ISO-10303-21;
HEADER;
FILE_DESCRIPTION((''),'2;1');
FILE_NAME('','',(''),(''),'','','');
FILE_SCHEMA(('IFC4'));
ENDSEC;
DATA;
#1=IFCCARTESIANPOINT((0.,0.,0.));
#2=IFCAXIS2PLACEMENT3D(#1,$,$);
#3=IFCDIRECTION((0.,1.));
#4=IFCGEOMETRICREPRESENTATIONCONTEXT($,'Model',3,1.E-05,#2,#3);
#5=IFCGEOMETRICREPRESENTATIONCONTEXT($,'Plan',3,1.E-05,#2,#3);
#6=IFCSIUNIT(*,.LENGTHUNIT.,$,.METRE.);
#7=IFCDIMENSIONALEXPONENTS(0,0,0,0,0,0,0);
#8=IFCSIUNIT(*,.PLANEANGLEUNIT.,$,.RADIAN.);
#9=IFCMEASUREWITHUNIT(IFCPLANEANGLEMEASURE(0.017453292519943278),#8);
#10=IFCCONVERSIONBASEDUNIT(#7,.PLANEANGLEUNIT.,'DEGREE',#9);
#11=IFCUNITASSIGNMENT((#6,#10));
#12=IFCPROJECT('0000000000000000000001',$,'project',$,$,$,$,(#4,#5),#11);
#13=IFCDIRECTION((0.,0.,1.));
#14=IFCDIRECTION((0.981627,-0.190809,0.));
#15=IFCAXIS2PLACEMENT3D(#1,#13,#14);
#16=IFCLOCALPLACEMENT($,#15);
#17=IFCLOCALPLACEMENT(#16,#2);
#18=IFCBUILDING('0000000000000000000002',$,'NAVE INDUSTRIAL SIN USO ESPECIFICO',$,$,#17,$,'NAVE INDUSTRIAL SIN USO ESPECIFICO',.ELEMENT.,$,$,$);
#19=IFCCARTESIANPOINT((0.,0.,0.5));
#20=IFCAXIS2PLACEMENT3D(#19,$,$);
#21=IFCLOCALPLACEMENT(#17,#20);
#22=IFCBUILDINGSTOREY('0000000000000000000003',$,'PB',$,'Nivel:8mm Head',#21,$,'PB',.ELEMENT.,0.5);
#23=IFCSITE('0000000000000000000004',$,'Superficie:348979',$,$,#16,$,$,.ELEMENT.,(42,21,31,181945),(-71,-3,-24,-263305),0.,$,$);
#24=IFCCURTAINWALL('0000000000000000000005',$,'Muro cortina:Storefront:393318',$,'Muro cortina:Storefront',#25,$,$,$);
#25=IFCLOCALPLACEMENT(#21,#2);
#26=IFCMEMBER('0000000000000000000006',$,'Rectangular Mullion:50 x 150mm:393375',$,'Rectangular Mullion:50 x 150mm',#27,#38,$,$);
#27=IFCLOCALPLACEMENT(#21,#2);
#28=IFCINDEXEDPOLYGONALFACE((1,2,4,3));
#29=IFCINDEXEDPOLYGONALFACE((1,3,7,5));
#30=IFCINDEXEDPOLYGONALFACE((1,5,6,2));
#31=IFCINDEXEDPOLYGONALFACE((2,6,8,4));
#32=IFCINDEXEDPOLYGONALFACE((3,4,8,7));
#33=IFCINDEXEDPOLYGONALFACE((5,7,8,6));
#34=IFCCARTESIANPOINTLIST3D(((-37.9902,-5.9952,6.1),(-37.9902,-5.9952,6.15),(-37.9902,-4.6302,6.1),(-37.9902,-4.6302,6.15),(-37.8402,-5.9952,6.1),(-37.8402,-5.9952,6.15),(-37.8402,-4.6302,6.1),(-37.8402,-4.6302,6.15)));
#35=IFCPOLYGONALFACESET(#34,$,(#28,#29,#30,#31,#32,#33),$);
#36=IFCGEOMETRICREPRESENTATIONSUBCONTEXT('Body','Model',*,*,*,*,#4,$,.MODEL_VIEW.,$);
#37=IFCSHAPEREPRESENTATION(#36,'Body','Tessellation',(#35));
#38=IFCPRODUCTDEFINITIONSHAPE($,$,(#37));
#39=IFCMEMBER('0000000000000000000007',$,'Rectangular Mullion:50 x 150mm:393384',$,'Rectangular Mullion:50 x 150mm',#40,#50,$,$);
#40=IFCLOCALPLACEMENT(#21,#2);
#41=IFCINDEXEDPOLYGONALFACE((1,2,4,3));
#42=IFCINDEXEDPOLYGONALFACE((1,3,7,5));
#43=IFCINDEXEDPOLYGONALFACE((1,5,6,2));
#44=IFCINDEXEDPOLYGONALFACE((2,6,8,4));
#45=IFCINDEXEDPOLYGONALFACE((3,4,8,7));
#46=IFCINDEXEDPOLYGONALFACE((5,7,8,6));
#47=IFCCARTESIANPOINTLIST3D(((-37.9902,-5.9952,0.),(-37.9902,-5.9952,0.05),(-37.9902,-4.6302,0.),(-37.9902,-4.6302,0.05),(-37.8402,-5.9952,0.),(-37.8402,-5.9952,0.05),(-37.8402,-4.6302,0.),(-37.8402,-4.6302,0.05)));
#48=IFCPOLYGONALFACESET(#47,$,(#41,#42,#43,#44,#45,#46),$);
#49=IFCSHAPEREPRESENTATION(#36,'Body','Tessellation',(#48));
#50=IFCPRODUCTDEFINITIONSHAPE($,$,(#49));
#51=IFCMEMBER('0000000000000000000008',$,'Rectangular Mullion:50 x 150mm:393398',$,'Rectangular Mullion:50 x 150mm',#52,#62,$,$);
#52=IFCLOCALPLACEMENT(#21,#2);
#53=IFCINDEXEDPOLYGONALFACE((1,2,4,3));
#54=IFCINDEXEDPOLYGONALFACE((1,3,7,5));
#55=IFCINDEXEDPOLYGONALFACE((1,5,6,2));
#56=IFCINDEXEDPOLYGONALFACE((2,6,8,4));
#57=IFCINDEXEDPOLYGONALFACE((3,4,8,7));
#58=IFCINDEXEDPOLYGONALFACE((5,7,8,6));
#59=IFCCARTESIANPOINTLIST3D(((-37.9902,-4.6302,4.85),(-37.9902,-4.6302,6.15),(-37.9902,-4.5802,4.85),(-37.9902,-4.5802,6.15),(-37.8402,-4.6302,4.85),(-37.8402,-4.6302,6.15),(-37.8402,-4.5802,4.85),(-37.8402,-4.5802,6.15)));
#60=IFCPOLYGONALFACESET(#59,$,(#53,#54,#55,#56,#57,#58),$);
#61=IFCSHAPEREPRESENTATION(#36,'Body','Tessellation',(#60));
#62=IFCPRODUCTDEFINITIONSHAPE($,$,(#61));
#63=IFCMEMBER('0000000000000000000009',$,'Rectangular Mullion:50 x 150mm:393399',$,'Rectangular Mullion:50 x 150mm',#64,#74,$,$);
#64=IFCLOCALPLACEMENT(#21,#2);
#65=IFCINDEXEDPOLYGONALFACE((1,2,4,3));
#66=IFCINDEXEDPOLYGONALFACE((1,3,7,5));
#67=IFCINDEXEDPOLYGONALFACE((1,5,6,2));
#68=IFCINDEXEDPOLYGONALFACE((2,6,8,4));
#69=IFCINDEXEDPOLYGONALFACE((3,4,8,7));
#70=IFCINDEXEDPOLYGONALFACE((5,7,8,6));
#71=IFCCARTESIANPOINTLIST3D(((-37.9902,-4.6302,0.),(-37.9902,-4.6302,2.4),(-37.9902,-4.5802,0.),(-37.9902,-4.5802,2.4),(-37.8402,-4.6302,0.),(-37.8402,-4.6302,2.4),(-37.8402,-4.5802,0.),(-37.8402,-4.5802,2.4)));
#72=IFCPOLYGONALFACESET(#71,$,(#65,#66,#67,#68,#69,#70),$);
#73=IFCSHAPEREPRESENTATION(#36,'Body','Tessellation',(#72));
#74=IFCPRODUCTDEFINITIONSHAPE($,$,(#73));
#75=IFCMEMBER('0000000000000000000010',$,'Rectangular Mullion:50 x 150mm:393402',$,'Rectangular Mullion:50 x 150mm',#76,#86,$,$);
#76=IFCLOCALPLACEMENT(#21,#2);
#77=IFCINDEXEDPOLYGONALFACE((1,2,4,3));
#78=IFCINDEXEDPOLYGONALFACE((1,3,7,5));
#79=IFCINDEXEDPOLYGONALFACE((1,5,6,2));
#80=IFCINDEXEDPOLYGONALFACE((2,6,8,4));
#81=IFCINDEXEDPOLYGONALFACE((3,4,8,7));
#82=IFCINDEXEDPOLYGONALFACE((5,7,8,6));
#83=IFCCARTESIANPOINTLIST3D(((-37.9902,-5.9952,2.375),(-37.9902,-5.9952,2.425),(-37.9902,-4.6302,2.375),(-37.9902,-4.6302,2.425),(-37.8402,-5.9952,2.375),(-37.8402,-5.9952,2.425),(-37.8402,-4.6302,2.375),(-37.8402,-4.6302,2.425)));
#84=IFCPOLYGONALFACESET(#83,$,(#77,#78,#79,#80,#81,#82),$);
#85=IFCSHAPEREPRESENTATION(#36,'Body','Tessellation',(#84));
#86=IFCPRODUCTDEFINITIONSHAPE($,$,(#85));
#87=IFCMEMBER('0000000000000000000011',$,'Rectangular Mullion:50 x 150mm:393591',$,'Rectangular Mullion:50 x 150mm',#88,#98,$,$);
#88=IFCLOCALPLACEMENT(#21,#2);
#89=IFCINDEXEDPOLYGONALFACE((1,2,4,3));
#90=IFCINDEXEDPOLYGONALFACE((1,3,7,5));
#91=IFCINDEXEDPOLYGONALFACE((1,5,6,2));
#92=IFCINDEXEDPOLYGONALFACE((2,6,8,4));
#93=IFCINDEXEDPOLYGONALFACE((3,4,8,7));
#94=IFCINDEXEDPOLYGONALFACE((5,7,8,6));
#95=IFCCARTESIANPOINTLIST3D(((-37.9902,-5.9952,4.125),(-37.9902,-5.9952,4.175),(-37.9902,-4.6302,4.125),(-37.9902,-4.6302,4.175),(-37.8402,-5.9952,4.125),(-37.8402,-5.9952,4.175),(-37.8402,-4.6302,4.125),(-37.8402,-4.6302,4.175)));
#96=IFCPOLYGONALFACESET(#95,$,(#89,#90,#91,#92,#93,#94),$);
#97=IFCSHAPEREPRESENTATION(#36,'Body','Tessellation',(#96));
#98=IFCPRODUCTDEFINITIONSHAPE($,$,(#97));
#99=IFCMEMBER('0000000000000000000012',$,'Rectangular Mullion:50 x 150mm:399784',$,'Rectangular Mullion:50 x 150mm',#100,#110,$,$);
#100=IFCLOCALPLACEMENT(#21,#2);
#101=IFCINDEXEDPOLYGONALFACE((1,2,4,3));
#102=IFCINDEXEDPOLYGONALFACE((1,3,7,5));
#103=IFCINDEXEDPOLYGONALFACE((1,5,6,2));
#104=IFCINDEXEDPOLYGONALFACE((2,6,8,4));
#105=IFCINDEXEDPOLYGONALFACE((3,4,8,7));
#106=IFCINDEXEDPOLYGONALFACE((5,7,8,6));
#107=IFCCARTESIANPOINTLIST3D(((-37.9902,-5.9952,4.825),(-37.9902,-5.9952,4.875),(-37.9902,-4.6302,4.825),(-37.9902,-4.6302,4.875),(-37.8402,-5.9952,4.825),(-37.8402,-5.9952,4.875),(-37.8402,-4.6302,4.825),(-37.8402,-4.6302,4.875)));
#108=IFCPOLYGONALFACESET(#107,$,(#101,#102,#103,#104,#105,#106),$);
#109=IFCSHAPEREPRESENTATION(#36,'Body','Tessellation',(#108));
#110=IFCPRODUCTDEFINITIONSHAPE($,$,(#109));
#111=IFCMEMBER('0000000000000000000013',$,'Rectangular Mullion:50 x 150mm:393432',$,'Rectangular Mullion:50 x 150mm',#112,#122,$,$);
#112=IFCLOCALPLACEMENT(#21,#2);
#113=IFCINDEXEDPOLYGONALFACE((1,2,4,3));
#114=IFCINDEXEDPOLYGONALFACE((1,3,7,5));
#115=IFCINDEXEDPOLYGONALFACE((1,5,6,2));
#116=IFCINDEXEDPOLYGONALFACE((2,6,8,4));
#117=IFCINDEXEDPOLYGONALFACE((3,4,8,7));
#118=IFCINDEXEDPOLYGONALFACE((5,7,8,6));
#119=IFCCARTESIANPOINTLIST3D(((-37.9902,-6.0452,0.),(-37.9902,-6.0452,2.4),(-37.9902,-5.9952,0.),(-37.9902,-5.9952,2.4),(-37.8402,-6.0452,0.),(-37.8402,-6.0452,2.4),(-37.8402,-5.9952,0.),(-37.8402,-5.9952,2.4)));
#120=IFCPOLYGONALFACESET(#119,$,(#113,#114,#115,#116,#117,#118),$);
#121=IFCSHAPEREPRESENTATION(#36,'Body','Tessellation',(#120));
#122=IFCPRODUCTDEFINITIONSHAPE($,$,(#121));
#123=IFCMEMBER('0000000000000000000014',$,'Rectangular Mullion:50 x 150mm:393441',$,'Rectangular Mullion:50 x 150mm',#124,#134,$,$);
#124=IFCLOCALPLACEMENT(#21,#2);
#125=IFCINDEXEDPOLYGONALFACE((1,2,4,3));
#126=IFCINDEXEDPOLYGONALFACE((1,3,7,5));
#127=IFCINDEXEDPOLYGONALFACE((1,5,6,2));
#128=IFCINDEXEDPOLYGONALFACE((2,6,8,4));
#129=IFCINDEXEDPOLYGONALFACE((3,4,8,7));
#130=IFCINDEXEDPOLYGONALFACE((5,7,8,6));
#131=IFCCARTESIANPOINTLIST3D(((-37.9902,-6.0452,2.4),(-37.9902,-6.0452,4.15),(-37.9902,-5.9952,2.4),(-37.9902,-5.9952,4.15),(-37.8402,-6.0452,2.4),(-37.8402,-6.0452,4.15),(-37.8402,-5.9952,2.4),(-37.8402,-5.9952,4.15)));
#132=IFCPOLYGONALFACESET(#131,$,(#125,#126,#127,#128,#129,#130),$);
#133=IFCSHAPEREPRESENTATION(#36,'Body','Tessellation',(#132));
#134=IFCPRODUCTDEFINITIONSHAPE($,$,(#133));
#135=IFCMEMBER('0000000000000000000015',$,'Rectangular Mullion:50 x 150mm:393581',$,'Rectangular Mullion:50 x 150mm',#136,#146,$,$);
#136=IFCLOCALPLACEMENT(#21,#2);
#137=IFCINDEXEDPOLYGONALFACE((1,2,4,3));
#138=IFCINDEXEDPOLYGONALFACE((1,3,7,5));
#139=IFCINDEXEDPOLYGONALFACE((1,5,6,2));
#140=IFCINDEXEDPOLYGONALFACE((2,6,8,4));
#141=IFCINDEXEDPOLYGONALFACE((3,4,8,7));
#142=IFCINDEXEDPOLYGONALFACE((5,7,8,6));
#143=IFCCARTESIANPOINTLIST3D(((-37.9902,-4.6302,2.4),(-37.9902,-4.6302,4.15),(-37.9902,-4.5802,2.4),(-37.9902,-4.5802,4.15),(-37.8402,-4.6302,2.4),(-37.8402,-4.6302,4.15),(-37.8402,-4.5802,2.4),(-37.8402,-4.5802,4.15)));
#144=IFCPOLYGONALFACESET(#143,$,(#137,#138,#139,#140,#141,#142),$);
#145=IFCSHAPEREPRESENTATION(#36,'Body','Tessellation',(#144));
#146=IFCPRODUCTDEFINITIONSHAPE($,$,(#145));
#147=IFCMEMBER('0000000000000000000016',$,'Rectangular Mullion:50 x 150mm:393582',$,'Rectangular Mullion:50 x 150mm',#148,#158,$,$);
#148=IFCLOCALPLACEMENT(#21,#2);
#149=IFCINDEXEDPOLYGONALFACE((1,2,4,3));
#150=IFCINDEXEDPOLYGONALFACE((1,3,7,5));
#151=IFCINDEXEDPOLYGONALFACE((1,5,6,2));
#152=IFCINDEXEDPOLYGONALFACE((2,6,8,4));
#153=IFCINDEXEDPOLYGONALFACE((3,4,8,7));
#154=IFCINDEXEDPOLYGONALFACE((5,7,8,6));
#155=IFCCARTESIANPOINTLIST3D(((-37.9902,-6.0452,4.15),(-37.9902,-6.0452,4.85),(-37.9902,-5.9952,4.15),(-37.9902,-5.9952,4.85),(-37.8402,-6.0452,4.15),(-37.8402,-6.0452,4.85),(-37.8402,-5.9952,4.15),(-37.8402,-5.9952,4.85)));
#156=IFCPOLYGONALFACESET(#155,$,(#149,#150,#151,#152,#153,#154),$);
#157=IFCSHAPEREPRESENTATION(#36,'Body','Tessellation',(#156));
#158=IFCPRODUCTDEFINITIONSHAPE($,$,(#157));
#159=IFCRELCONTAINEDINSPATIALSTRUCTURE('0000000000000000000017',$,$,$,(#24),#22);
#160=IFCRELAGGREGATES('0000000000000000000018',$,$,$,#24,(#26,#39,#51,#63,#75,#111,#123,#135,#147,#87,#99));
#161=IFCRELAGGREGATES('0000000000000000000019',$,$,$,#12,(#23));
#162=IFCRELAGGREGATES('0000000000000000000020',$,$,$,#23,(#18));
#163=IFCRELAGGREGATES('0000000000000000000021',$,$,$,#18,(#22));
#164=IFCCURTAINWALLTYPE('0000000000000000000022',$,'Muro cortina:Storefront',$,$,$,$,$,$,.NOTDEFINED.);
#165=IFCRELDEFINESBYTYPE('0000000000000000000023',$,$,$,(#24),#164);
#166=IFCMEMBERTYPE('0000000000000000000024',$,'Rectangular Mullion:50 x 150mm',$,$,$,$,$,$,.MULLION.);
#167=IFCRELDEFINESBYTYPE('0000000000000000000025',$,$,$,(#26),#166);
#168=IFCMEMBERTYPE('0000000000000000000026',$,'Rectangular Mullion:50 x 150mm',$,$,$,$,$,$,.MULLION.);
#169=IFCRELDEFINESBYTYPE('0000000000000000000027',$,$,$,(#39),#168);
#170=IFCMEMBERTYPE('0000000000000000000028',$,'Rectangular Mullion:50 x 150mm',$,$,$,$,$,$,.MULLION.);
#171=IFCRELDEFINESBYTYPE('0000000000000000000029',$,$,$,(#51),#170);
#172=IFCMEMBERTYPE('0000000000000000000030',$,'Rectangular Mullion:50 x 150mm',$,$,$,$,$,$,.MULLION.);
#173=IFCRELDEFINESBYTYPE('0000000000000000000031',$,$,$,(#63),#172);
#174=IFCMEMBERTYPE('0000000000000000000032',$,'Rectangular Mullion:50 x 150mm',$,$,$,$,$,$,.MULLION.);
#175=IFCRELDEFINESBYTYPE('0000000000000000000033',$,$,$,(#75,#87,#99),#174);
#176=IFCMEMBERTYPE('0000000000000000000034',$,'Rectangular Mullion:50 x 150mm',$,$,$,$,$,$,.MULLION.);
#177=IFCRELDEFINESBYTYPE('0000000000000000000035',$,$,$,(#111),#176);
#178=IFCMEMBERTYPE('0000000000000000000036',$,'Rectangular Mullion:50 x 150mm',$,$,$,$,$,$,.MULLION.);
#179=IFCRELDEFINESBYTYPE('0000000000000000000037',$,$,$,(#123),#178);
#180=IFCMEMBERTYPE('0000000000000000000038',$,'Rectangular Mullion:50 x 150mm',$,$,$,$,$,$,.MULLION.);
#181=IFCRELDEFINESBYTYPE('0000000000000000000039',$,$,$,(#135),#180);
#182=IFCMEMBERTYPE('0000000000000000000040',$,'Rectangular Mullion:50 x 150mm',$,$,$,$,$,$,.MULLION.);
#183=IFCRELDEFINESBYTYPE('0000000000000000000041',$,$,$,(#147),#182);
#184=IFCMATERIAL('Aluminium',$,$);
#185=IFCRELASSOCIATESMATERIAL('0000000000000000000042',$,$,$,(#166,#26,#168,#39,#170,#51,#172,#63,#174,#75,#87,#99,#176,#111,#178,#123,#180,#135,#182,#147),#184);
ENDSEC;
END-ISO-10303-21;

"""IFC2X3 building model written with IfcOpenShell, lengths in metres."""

from ifc_helpers import new_model, entity, si_unit, converted_unit, direction, frame, origin, origin_2d_with_axis, place, context, subcontext, project, spatial, rectangle, extrude, source, transform, mapped, material, type_object, type_shapes, element, aggregate, save


model = new_model("IFC2X3")

# Units and contexts
model_context = context("Model", 3, precision=1e-05, world=origin(), true_north=direction((0.0, 1.0)))
plan_context = context("Plan", 3, precision=1e-05, world=origin(), true_north=direction((0.0, 1.0)))
body_context = subcontext(model_context, "Body", "Model", "MODEL_VIEW")
ifc_project = project(units=[si_unit("LENGTHUNIT", "METRE"), converted_unit("PLANEANGLEUNIT", "DEGREE", entity("IfcPlaneAngleMeasure", 0.017453292519943278), si_unit("PLANEANGLEUNIT", "RADIAN"), dimensions=[0, 0, 0, 0, 0, 0, 0])], contexts=[model_context, plan_context])

# Site, building, storey
site_placement = place(None, frame((0.0, 0.0, 0.0), z_axis=(0.0, 0.0, 1.0), x_axis=(0.981627, -0.190809, 0.0)))
site = spatial("IfcSite", under=ifc_project, at=site_placement, Name="Superficie:348979", CompositionType="ELEMENT", RefLatitude=(42, 21, 31, 181945), RefLongitude=(-71, -3, -24, -263305), RefElevation=0.0)
building_placement = place(site_placement, origin())
building = spatial("IfcBuilding", under=site, at=building_placement, Name="NAVE INDUSTRIAL SIN USO ESPECIFICO", LongName="NAVE INDUSTRIAL SIN USO ESPECIFICO", CompositionType="ELEMENT")
storey_placement = place(building_placement, frame((0.0, 0.0, 0.5)))
storey = spatial("IfcBuildingStorey", under=building, at=storey_placement, Name="PB", ObjectType="Nivel:8mm Head", LongName="PB", CompositionType="ELEMENT", Elevation=0.5)

# Curtain wall, members
curtain_wall_type = type_object("IfcCurtainWallType", Name="Muro cortina:Storefront", PredefinedType="NOTDEFINED")
curtain_wall_placement = place(storey_placement, frame((0.0, 0.0, -0.5)))
curtain_wall = element("IfcCurtainWall", 1, at=curtain_wall_placement, inside=storey, type_object=curtain_wall_type, Name="Muro cortina:Storefront:393318", ObjectType="Muro cortina:Storefront")
ifc_material_1 = material(Name="Aluminium")
member_type_1 = type_object("IfcMemberType", Name="Rectangular Mullion:50 x 150mm", PredefinedType="MULLION", material=ifc_material_1)
shared_shape_1 = source(origin(), body_context, "Body", "SweptSolid", [
    extrude(rectangle(XDim=0.05, YDim=0.15, at=origin_2d_with_axis()), frame((-0.025, 0.0, -1.365), z_axis=(0.0, 0.0, 1.0), x_axis=(-1.0, 0.0, 0.0)), (0.0, 0.0, 1.0), 1.365),
])
type_shapes(member_type_1, [shared_shape_1])
member_1_placement = place(curtain_wall_placement, frame((-37.9152, -5.9952, 6.65), z_axis=(0.0, -1.0, 0.0), x_axis=(0.0, 0.0, 1.0)))
member_1 = element("IfcMember", 2, at=member_1_placement, type_object=member_type_1, material=ifc_material_1, Name="Rectangular Mullion:50 x 150mm:393375", ObjectType="Rectangular Mullion:50 x 150mm", context=body_context, shape_type="MappedRepresentation", body=[
    mapped(shared_shape_1, transform((0.0, 0.0, 0.0), scale=1.0)),
])
member_type_2 = type_object("IfcMemberType", Name="Rectangular Mullion:50 x 150mm", PredefinedType="MULLION", material=ifc_material_1)
shared_shape_2 = source(origin(), body_context, "Body", "SweptSolid", [
    extrude(rectangle(XDim=0.05, YDim=0.15, at=origin_2d_with_axis()), frame((-0.025, 0.0, -1.365), z_axis=(0.0, 0.0, 1.0), x_axis=(-1.0, 0.0, 0.0)), (0.0, 0.0, 1.0), 1.365),
])
type_shapes(member_type_2, [shared_shape_2])
member_2_placement = place(curtain_wall_placement, frame((-37.9152, -4.6302, 0.5), z_axis=(0.0, 1.0, 0.0), x_axis=(0.0, 0.0, -1.0)))
member_2 = element("IfcMember", 3, at=member_2_placement, type_object=member_type_2, material=ifc_material_1, Name="Rectangular Mullion:50 x 150mm:393384", ObjectType="Rectangular Mullion:50 x 150mm", context=body_context, shape_type="MappedRepresentation", body=[
    mapped(shared_shape_2, transform((0.0, 0.0, 0.0), scale=1.0)),
])
member_type_3 = type_object("IfcMemberType", Name="Rectangular Mullion:50 x 150mm", PredefinedType="MULLION", material=ifc_material_1)
shared_shape_3 = source(origin(), body_context, "Body", "SweptSolid", [
    extrude(rectangle(XDim=0.05, YDim=0.15, at=origin_2d_with_axis()), frame((-0.025, 0.0, -1.3), z_axis=(0.0, 0.0, 1.0), x_axis=(-1.0, 0.0, 0.0)), (0.0, 0.0, 1.0), 1.3),
])
type_shapes(member_type_3, [shared_shape_3])
member_3_placement = place(curtain_wall_placement, frame((-37.9152, -4.5802, 6.65), z_axis=(0.0, 0.0, 1.0), x_axis=(0.0, 1.0, 0.0)))
member_3 = element("IfcMember", 4, at=member_3_placement, type_object=member_type_3, material=ifc_material_1, Name="Rectangular Mullion:50 x 150mm:393398", ObjectType="Rectangular Mullion:50 x 150mm", context=body_context, shape_type="MappedRepresentation", body=[
    mapped(shared_shape_3, transform((0.0, 0.0, 0.0), scale=1.0)),
])
member_type_4 = type_object("IfcMemberType", Name="Rectangular Mullion:50 x 150mm", PredefinedType="MULLION", material=ifc_material_1)
shared_shape_4 = source(origin(), body_context, "Body", "SweptSolid", [
    extrude(rectangle(XDim=0.05, YDim=0.15, at=origin_2d_with_axis()), frame((-0.025, 0.0, -2.4), z_axis=(0.0, 0.0, 1.0), x_axis=(-1.0, 0.0, 0.0)), (0.0, 0.0, 1.0), 2.4),
])
type_shapes(member_type_4, [shared_shape_4])
member_4_placement = place(curtain_wall_placement, frame((-37.9152, -4.5802, 2.9), z_axis=(0.0, 0.0, 1.0), x_axis=(0.0, 1.0, 0.0)))
member_4 = element("IfcMember", 5, at=member_4_placement, type_object=member_type_4, material=ifc_material_1, Name="Rectangular Mullion:50 x 150mm:393399", ObjectType="Rectangular Mullion:50 x 150mm", context=body_context, shape_type="MappedRepresentation", body=[
    mapped(shared_shape_4, transform((0.0, 0.0, 0.0), scale=1.0)),
])
member_type_5 = type_object("IfcMemberType", Name="Rectangular Mullion:50 x 150mm", PredefinedType="MULLION", material=ifc_material_1)
shared_shape_5 = source(origin(), body_context, "Body", "SweptSolid", [
    extrude(rectangle(XDim=0.05, YDim=0.15, at=origin_2d_with_axis()), frame((0.0, 0.0, -1.365), z_axis=(0.0, 0.0, 1.0), x_axis=(-1.0, 0.0, 0.0)), (0.0, 0.0, 1.0), 1.365),
])
type_shapes(member_type_5, [shared_shape_5])
member_5_placement = place(curtain_wall_placement, frame((-37.9152, -5.9952, 2.9), z_axis=(0.0, -1.0, 0.0), x_axis=(0.0, 0.0, 1.0)))
member_5 = element("IfcMember", 6, at=member_5_placement, type_object=member_type_5, material=ifc_material_1, Name="Rectangular Mullion:50 x 150mm:393402", ObjectType="Rectangular Mullion:50 x 150mm", context=body_context, shape_type="MappedRepresentation", body=[
    mapped(shared_shape_5, transform((0.0, 0.0, 0.0), scale=1.0)),
])
member_6_placement = place(curtain_wall_placement, frame((-37.9152, -5.9952, 4.65), z_axis=(0.0, -1.0, 0.0), x_axis=(0.0, 0.0, 1.0)))
member_6 = element("IfcMember", 7, at=member_6_placement, type_object=member_type_5, material=ifc_material_1, Name="Rectangular Mullion:50 x 150mm:393591", ObjectType="Rectangular Mullion:50 x 150mm", context=body_context, shape_type="MappedRepresentation", body=[
    mapped(shared_shape_5, transform((0.0, 0.0, 0.0), scale=1.0)),
])
member_7_placement = place(curtain_wall_placement, frame((-37.9152, -5.9952, 5.35), z_axis=(0.0, -1.0, 0.0), x_axis=(0.0, 0.0, 1.0)))
member_7 = element("IfcMember", 8, at=member_7_placement, type_object=member_type_5, material=ifc_material_1, Name="Rectangular Mullion:50 x 150mm:399784", ObjectType="Rectangular Mullion:50 x 150mm", context=body_context, shape_type="MappedRepresentation", body=[
    mapped(shared_shape_5, transform((0.0, 0.0, 0.0), scale=1.0)),
])
member_type_6 = type_object("IfcMemberType", Name="Rectangular Mullion:50 x 150mm", PredefinedType="MULLION", material=ifc_material_1)
shared_shape_6 = source(origin(), body_context, "Body", "SweptSolid", [
    extrude(rectangle(XDim=0.05, YDim=0.15, at=origin_2d_with_axis()), frame((0.0, 0.0, -2.4), z_axis=(0.0, 0.0, 1.0), x_axis=(-1.0, 0.0, 0.0)), (0.0, 0.0, 1.0), 2.4),
])
type_shapes(member_type_6, [shared_shape_6])
member_8_placement = place(curtain_wall_placement, frame((-37.9152, -6.0202, 0.5), z_axis=(0.0, 0.0, -1.0), x_axis=(0.0, -1.0, 0.0)))
member_8 = element("IfcMember", 9, at=member_8_placement, type_object=member_type_6, material=ifc_material_1, Name="Rectangular Mullion:50 x 150mm:393432", ObjectType="Rectangular Mullion:50 x 150mm", context=body_context, shape_type="MappedRepresentation", body=[
    mapped(shared_shape_6, transform((0.0, 0.0, 0.0), scale=1.0)),
])
member_type_7 = type_object("IfcMemberType", Name="Rectangular Mullion:50 x 150mm", PredefinedType="MULLION", material=ifc_material_1)
shared_shape_7 = source(origin(), body_context, "Body", "SweptSolid", [
    extrude(rectangle(XDim=0.05, YDim=0.15, at=origin_2d_with_axis()), frame((0.0, 0.0, -1.75), z_axis=(0.0, 0.0, 1.0), x_axis=(-1.0, 0.0, 0.0)), (0.0, 0.0, 1.0), 1.75),
])
type_shapes(member_type_7, [shared_shape_7])
member_9_placement = place(curtain_wall_placement, frame((-37.9152, -6.0202, 2.9), z_axis=(0.0, 0.0, -1.0), x_axis=(0.0, -1.0, 0.0)))
member_9 = element("IfcMember", 10, at=member_9_placement, type_object=member_type_7, material=ifc_material_1, Name="Rectangular Mullion:50 x 150mm:393441", ObjectType="Rectangular Mullion:50 x 150mm", context=body_context, shape_type="MappedRepresentation", body=[
    mapped(shared_shape_7, transform((0.0, 0.0, 0.0), scale=1.0)),
])
member_type_8 = type_object("IfcMemberType", Name="Rectangular Mullion:50 x 150mm", PredefinedType="MULLION", material=ifc_material_1)
shared_shape_8 = source(origin(), body_context, "Body", "SweptSolid", [
    extrude(rectangle(XDim=0.05, YDim=0.15, at=origin_2d_with_axis()), frame((-0.025, 0.0, -1.75), z_axis=(0.0, 0.0, 1.0), x_axis=(-1.0, 0.0, 0.0)), (0.0, 0.0, 1.0), 1.75),
])
type_shapes(member_type_8, [shared_shape_8])
member_10_placement = place(curtain_wall_placement, frame((-37.9152, -4.5802, 4.65), z_axis=(0.0, 0.0, 1.0), x_axis=(0.0, 1.0, 0.0)))
member_10 = element("IfcMember", 11, at=member_10_placement, type_object=member_type_8, material=ifc_material_1, Name="Rectangular Mullion:50 x 150mm:393581", ObjectType="Rectangular Mullion:50 x 150mm", context=body_context, shape_type="MappedRepresentation", body=[
    mapped(shared_shape_8, transform((0.0, 0.0, 0.0), scale=1.0)),
])
member_type_9 = type_object("IfcMemberType", Name="Rectangular Mullion:50 x 150mm", PredefinedType="MULLION", material=ifc_material_1)
shared_shape_9 = source(origin(), body_context, "Body", "SweptSolid", [
    extrude(rectangle(XDim=0.05, YDim=0.15, at=origin_2d_with_axis()), frame((0.0, 0.0, -0.7), z_axis=(0.0, 0.0, 1.0), x_axis=(-1.0, 0.0, 0.0)), (0.0, 0.0, 1.0), 0.7),
])
type_shapes(member_type_9, [shared_shape_9])
member_11_placement = place(curtain_wall_placement, frame((-37.9152, -6.0202, 4.65), z_axis=(0.0, 0.0, -1.0), x_axis=(0.0, -1.0, 0.0)))
member_11 = element("IfcMember", 12, at=member_11_placement, type_object=member_type_9, material=ifc_material_1, Name="Rectangular Mullion:50 x 150mm:393582", ObjectType="Rectangular Mullion:50 x 150mm", context=body_context, shape_type="MappedRepresentation", body=[
    mapped(shared_shape_9, transform((0.0, 0.0, 0.0), scale=1.0)),
])
aggregate(curtain_wall, [member_1, member_2, member_3, member_4, member_5, member_8, member_9, member_10, member_11, member_6, member_7])

save(model, "model.ifc")
